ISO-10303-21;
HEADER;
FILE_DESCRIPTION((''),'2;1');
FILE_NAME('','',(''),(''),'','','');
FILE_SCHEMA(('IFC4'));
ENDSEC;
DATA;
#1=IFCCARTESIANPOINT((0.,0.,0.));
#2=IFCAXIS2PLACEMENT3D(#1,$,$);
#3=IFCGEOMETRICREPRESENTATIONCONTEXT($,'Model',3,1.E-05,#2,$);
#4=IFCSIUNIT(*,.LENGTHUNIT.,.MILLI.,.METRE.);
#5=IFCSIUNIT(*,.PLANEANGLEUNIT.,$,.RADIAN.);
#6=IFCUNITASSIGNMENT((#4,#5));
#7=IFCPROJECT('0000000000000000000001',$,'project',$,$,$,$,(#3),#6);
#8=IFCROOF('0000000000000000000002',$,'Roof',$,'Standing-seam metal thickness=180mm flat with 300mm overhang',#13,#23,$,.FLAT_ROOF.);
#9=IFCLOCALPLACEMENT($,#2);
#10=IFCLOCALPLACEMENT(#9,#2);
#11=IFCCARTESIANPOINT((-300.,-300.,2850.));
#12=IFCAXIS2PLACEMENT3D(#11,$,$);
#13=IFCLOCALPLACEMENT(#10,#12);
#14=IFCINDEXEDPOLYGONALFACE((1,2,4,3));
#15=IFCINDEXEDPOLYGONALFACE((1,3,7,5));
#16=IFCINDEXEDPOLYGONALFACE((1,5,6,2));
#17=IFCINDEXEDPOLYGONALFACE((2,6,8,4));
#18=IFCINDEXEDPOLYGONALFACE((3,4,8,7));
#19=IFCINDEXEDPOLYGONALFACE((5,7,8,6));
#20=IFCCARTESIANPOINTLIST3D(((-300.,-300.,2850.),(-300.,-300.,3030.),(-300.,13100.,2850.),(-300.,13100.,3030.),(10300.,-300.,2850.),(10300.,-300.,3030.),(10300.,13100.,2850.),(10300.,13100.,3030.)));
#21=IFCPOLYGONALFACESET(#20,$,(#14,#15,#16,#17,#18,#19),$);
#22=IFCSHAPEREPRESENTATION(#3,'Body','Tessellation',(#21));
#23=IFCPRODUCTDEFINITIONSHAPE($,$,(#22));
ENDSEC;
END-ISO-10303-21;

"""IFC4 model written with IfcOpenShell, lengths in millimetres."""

from ifc_helpers import new_model, si_unit, frame, frame_2d, origin, place, context, project, rectangle, extrude, element, save


model = new_model("IFC4")

# Units and contexts
model_context = context("Model", 3, precision=1e-05, world=origin())
ifc_project = project(units=[si_unit("LENGTHUNIT", "METRE", prefix="MILLI"), si_unit("PLANEANGLEUNIT", "RADIAN")], contexts=[model_context])

# Roof
placement_1 = place(None, origin())
placement_2 = place(placement_1, origin())
roof_placement = place(placement_2, frame((-300.0, -300.0, 2850.0)))
element("IfcRoof", 1, at=roof_placement, Name="Roof", ObjectType="Standing-seam metal thickness=180mm flat with 300mm overhang", PredefinedType="FLAT_ROOF", context=model_context, shape_type="SweptSolid", body=[
    extrude(rectangle(XDim=10600.0, YDim=13400.0, at=frame_2d((5300.0, 6700.0))), frame((-300.0, -300.0, 2850.0)), (0.0, 0.0, 1.0), 180.0),
])

save(model, "model.ifc")
